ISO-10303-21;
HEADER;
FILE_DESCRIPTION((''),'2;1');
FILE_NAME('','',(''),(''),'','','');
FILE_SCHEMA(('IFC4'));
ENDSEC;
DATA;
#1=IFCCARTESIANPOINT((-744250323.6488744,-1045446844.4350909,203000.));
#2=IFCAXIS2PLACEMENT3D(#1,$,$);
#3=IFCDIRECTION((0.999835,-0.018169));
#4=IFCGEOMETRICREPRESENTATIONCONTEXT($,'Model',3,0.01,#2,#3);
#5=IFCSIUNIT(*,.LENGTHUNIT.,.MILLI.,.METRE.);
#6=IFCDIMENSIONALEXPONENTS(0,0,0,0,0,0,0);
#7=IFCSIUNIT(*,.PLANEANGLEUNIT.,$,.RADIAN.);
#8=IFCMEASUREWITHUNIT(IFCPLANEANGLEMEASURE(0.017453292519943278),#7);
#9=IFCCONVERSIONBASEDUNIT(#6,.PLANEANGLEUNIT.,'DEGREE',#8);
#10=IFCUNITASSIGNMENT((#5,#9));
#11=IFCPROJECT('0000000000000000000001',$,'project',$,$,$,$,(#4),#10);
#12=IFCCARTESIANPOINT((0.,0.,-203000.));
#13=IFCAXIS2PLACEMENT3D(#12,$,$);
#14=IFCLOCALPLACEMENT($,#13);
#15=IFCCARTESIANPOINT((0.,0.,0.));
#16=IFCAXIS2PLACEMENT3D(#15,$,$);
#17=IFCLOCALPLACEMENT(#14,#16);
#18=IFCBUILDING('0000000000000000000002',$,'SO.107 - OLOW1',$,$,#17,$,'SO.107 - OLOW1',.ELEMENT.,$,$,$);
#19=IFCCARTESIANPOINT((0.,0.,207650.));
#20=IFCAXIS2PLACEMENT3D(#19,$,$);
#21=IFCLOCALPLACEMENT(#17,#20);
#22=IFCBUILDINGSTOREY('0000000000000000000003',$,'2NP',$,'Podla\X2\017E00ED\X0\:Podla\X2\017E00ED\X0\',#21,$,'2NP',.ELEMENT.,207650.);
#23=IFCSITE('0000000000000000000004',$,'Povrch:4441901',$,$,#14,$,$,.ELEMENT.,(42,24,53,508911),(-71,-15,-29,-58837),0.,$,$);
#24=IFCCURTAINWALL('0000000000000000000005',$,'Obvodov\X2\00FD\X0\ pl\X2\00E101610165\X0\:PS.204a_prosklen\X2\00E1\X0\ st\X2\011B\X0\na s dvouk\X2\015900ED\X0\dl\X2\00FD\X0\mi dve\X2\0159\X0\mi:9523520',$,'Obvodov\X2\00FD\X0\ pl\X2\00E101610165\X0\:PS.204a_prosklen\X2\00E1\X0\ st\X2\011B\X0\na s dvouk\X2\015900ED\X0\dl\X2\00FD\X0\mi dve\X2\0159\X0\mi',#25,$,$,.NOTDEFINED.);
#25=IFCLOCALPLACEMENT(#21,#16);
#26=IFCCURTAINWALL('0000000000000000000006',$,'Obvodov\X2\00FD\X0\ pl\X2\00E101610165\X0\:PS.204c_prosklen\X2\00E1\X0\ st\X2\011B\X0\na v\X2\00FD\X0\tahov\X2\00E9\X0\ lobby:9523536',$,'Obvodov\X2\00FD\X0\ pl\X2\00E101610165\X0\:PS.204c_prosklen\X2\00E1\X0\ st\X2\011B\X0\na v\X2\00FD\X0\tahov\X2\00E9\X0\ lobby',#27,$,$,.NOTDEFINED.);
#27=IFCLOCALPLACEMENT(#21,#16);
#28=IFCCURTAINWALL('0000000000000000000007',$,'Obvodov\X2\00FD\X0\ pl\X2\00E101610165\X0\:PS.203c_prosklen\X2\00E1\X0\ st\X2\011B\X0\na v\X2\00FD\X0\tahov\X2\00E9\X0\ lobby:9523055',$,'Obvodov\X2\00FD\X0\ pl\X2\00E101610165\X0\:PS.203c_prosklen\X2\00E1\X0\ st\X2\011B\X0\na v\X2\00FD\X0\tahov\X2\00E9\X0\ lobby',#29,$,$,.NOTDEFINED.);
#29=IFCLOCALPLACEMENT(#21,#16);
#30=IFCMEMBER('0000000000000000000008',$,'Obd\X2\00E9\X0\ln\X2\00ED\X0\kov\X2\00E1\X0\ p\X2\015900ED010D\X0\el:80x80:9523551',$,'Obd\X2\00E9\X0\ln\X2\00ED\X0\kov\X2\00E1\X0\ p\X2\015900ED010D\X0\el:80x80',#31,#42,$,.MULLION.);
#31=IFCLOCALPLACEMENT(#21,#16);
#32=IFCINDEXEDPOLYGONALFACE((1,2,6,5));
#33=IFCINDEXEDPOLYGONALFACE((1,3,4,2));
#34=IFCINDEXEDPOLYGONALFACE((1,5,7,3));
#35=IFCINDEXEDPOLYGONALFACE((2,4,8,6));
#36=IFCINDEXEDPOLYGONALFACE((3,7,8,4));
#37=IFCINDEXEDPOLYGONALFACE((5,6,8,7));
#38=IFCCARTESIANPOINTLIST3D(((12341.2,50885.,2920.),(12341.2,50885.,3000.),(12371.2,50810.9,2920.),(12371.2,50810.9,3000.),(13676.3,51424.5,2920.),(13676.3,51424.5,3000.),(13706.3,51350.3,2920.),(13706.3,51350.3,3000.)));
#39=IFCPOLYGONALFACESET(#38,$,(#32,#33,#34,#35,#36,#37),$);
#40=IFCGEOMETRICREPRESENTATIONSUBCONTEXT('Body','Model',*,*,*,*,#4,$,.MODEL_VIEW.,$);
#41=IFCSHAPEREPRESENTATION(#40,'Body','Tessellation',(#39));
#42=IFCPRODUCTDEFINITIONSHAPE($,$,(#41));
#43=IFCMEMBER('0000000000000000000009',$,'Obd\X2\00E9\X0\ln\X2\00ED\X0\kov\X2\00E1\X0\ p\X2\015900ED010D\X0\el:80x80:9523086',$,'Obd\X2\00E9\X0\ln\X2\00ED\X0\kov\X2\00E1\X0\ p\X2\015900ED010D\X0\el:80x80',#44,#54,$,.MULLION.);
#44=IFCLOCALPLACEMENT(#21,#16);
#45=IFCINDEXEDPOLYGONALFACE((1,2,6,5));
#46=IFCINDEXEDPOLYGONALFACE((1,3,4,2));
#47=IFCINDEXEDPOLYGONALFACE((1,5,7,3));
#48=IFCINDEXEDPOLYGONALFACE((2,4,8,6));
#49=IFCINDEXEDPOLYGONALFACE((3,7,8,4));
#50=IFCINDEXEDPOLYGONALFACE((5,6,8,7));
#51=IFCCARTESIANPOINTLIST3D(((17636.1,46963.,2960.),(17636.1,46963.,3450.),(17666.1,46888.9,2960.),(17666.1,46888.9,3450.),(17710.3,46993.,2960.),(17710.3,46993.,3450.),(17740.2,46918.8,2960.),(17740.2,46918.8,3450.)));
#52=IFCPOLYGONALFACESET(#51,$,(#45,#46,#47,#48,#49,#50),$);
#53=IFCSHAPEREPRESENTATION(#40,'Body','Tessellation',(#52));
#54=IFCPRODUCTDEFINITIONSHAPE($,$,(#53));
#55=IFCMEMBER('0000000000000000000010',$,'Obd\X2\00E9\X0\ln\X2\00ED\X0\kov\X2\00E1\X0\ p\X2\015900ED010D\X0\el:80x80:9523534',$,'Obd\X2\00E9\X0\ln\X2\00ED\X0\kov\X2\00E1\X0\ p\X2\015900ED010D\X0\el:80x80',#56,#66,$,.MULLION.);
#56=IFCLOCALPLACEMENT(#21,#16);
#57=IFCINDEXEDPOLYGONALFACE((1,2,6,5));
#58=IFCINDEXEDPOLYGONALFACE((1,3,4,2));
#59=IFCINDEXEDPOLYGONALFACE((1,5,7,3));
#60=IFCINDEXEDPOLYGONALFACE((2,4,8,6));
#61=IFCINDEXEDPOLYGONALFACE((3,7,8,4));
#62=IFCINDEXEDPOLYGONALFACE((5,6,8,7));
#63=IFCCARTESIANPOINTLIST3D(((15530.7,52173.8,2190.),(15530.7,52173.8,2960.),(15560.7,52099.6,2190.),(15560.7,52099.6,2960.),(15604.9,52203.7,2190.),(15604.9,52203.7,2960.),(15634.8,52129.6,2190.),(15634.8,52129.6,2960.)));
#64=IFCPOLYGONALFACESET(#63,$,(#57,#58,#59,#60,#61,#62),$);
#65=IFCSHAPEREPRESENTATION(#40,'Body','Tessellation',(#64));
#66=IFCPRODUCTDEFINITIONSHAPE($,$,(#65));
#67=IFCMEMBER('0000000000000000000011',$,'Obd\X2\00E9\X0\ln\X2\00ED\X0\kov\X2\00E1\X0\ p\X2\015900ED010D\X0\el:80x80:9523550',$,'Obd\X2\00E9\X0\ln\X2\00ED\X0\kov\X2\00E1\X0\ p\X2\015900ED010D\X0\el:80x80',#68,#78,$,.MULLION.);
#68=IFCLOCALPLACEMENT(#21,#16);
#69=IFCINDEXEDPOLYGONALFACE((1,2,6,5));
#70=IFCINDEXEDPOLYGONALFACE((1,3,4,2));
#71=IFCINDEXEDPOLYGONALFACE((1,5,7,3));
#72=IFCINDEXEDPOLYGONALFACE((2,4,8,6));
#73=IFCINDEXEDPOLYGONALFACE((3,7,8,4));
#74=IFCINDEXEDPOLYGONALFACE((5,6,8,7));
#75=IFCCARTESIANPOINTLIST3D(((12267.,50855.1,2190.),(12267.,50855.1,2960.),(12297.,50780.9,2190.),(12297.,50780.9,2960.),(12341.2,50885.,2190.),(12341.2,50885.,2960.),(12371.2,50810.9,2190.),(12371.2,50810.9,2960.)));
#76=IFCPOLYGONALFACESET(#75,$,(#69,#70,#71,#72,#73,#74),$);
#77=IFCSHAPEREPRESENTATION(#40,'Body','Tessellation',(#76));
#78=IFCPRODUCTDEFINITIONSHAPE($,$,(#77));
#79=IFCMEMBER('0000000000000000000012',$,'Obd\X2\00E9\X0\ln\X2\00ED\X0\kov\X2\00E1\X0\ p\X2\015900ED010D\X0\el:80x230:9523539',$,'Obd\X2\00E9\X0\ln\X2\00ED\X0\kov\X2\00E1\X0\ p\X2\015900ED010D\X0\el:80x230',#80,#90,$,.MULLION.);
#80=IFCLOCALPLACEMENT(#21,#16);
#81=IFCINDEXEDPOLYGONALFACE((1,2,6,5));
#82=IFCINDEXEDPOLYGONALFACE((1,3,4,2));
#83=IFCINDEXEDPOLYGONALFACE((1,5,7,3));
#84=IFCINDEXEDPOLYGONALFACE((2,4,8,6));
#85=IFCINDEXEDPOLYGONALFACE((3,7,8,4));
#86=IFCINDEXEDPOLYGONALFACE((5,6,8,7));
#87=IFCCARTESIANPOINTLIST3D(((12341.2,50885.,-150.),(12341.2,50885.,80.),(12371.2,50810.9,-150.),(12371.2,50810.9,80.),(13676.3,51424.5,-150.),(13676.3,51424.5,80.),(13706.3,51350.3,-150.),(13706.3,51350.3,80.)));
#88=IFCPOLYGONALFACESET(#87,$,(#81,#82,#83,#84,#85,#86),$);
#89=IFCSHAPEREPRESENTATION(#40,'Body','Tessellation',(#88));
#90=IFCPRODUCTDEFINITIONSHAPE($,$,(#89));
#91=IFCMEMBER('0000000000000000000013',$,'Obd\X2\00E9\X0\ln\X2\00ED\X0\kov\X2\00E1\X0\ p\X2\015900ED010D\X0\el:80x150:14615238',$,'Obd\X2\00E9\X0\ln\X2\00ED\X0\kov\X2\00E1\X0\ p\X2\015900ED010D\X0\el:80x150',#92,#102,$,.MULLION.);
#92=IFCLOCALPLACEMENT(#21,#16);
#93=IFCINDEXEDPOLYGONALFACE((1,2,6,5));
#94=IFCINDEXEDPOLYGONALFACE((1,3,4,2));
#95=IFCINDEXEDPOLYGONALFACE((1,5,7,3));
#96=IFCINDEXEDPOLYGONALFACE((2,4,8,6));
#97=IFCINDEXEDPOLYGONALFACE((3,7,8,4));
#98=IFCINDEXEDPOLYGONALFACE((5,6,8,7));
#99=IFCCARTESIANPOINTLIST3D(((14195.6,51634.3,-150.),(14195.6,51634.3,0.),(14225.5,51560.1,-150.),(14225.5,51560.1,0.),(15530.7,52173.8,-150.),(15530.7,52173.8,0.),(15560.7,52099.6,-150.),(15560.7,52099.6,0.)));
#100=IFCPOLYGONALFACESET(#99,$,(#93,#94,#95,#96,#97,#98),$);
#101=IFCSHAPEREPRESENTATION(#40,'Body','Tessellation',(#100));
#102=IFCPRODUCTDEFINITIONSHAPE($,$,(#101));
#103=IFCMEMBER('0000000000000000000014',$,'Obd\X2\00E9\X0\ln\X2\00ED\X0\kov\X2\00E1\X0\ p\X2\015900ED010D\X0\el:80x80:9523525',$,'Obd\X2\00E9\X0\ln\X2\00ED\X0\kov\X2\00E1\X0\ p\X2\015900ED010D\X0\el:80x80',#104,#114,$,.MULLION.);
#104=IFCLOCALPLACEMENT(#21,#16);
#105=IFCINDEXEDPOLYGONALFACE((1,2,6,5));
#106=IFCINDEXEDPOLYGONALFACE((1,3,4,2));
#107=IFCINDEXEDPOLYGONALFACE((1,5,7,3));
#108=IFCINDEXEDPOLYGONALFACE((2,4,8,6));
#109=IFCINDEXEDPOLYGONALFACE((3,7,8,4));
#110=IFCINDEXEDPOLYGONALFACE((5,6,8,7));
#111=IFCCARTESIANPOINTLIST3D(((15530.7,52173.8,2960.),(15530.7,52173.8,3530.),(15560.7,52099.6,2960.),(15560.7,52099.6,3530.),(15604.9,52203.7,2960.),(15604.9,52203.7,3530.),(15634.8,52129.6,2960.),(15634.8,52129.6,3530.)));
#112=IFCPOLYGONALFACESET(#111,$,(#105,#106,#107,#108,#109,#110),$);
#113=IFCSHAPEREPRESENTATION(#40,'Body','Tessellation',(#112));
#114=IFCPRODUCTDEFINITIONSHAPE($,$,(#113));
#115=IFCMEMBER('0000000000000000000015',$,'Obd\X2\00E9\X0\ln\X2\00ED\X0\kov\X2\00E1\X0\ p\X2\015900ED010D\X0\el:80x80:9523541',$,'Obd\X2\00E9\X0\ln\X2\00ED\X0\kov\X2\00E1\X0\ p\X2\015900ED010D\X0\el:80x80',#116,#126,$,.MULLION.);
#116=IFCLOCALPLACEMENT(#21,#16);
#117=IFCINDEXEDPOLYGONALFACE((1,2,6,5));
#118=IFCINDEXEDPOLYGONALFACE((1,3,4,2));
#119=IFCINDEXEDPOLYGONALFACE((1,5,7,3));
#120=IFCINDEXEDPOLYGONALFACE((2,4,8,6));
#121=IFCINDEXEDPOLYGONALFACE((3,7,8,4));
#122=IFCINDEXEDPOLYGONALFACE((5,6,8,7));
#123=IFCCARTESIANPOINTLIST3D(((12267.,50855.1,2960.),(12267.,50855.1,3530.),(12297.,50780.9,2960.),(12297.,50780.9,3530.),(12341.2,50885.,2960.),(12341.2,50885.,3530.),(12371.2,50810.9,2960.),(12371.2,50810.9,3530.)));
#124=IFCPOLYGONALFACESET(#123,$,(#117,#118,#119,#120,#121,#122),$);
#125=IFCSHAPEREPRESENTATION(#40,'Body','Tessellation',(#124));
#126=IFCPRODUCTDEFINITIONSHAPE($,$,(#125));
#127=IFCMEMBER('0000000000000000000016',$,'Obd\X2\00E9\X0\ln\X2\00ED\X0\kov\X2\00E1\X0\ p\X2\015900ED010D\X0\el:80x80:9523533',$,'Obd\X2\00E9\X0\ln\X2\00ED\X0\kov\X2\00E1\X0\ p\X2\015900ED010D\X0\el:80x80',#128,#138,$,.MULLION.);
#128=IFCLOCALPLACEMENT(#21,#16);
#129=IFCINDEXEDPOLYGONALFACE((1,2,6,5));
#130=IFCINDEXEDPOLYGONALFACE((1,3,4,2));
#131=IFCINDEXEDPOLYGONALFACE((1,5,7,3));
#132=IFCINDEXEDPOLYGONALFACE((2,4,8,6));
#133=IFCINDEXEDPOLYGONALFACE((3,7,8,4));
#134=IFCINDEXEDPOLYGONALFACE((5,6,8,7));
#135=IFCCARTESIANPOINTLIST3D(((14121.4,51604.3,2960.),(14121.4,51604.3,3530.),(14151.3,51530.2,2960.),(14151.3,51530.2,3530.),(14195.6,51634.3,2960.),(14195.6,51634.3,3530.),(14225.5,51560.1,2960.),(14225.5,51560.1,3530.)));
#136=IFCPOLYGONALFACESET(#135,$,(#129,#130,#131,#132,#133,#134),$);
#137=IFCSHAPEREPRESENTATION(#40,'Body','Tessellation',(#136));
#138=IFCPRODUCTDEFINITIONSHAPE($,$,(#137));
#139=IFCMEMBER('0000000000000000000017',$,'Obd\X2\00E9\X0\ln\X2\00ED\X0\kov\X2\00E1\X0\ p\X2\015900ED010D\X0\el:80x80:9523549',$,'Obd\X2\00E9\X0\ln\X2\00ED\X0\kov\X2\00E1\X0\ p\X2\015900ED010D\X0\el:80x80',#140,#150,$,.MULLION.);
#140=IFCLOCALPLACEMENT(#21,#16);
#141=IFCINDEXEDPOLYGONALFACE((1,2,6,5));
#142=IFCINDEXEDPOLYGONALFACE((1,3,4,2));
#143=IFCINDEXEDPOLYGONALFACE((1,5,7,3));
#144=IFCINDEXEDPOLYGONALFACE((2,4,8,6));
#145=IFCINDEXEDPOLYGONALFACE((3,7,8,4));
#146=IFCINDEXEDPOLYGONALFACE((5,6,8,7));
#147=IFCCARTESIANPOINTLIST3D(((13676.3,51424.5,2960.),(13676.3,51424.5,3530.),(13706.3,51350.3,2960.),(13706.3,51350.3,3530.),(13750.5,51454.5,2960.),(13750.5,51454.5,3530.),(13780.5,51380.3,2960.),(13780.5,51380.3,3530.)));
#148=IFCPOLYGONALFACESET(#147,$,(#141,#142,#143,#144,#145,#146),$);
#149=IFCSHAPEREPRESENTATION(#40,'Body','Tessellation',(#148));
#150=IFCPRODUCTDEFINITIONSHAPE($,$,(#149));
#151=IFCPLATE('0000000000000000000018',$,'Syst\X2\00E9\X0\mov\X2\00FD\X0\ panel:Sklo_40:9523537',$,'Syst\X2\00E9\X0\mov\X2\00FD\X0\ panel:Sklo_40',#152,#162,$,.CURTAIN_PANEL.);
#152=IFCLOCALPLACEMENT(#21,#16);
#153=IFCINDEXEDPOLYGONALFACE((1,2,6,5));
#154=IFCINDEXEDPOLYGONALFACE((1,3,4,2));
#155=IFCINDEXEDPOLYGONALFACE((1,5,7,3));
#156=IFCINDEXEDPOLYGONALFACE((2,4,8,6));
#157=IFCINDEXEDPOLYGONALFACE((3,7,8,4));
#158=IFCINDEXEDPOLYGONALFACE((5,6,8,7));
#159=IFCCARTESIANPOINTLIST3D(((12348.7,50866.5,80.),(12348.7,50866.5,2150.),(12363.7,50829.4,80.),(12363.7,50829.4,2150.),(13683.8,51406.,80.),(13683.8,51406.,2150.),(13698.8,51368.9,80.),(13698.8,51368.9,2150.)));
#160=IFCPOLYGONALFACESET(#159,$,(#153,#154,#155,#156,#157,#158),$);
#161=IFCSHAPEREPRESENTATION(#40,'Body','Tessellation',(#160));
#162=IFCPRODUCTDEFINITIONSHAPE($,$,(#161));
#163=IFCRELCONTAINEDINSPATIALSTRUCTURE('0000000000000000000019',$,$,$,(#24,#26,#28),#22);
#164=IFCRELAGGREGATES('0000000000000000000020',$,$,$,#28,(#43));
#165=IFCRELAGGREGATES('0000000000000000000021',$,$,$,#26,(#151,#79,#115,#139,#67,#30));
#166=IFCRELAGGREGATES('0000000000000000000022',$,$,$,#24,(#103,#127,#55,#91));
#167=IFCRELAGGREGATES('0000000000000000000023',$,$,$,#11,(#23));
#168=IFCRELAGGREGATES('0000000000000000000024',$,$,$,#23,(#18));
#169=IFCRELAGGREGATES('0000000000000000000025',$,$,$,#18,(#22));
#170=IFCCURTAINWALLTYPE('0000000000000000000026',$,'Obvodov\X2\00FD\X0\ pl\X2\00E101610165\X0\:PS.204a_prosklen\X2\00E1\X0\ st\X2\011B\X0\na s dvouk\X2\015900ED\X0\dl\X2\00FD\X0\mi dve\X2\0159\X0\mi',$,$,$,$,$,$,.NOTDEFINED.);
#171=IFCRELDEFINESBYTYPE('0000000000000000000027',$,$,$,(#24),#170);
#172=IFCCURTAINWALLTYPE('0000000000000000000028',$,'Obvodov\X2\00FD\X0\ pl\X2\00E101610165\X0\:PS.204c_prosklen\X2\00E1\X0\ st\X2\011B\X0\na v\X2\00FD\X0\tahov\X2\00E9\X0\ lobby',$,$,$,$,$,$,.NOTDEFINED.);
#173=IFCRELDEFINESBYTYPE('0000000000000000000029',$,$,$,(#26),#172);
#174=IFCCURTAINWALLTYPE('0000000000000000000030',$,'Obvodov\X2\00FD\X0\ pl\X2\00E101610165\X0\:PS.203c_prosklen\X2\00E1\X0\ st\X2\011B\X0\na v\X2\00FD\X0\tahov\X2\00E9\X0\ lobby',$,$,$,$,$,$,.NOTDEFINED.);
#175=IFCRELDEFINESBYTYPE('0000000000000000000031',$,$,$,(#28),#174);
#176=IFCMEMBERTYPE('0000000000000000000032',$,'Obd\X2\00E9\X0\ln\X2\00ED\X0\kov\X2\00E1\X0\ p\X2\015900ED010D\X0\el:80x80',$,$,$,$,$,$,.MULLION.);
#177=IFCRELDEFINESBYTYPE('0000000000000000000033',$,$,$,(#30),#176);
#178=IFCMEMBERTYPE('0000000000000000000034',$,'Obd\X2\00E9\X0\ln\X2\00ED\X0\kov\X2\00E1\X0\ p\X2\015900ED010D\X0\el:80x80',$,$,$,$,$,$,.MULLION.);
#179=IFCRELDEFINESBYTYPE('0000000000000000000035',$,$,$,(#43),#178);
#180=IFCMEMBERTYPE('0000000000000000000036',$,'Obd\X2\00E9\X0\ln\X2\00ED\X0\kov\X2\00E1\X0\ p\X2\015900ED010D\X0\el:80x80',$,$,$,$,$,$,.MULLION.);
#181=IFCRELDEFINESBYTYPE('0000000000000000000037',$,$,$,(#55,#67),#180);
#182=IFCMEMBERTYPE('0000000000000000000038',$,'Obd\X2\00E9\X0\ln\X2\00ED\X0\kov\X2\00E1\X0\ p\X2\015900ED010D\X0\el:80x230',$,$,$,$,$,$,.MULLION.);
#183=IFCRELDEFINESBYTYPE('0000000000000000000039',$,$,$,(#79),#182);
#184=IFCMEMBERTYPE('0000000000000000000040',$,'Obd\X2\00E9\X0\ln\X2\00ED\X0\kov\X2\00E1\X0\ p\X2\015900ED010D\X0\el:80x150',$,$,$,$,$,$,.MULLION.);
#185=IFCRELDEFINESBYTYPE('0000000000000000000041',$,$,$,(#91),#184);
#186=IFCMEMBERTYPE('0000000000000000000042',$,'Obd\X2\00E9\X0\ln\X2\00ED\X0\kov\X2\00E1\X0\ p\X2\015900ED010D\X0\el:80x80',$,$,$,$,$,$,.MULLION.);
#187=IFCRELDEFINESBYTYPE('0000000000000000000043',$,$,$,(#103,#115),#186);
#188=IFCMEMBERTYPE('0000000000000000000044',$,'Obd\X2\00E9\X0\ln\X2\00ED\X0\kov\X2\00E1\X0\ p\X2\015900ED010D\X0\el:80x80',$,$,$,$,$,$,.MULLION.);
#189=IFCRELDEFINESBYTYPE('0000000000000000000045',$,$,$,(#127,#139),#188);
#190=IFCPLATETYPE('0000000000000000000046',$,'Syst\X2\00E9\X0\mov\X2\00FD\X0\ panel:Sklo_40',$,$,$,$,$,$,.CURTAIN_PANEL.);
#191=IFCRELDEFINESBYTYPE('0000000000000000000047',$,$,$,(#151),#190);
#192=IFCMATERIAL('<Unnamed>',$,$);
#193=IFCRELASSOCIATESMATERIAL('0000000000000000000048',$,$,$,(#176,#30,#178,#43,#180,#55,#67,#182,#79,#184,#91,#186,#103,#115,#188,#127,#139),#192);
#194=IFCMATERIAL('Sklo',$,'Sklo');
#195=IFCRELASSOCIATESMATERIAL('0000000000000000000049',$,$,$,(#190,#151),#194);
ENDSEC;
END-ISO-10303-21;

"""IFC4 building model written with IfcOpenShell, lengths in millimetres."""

from ifc_helpers import new_model, entity, si_unit, converted_unit, direction, frame, origin, place, context, subcontext, project, spatial, indexed_curve, outline, extrude, source, transform, mapped, material, type_object, type_shapes, element, aggregate, save


model = new_model("IFC4")

# Units and contexts
model_context = context("Model", 3, precision=0.01, world=frame((-744250323.6488744, -1045446844.4350909, 203000.0)), true_north=direction((0.999835, -0.018169)))
body_context = subcontext(model_context, "Body", "Model", "MODEL_VIEW")
ifc_project = project(units=[si_unit("LENGTHUNIT", "METRE", prefix="MILLI"), converted_unit("PLANEANGLEUNIT", "DEGREE", entity("IfcPlaneAngleMeasure", 0.017453292519943278), si_unit("PLANEANGLEUNIT", "RADIAN"), dimensions=[0, 0, 0, 0, 0, 0, 0])], contexts=[model_context])

# Site, building, storey
site_placement = place(None, frame((0.0, 0.0, -203000.0)))
site = spatial("IfcSite", under=ifc_project, at=site_placement, Name="Povrch:4441901", CompositionType="ELEMENT", RefLatitude=(42, 24, 53, 508911), RefLongitude=(-71, -15, -29, -58837), RefElevation=0.0)
building_placement = place(site_placement, origin())
building = spatial("IfcBuilding", under=site, at=building_placement, Name="SO.107 - OLOW1", LongName="SO.107 - OLOW1", CompositionType="ELEMENT")
storey_placement = place(building_placement, frame((0.0, 0.0, 207650.0)))
storey = spatial("IfcBuildingStorey", under=building, at=storey_placement, Name="2NP", ObjectType="Podlaží:Podlaží", LongName="2NP", CompositionType="ELEMENT", Elevation=207650.0)

# Curtain walls
curtain_wall_type_1 = type_object("IfcCurtainWallType", Name="Obvodový plášť:PS.204a_prosklená stěna s dvoukřídlými dveřmi", PredefinedType="NOTDEFINED")
curtain_wall_1_placement = place(storey_placement, frame((0.0, 0.0, -207650.0)))
curtain_wall_1 = element("IfcCurtainWall", 1, at=curtain_wall_1_placement, inside=storey, type_object=curtain_wall_type_1, Name="Obvodový plášť:PS.204a_prosklená stěna s dvoukřídlými dveřmi:9523520", ObjectType="Obvodový plášť:PS.204a_prosklená stěna s dvoukřídlými dveřmi", PredefinedType="NOTDEFINED")
ifc_material_1 = material(Name="<Unnamed>")
curtain_wall_type_2 = type_object("IfcCurtainWallType", Name="Obvodový plášť:PS.204c_prosklená stěna výtahové lobby", PredefinedType="NOTDEFINED")
curtain_wall_2_placement = place(storey_placement, frame((0.0, 0.0, -207650.0)))
curtain_wall_2 = element("IfcCurtainWall", 2, at=curtain_wall_2_placement, inside=storey, type_object=curtain_wall_type_2, Name="Obvodový plášť:PS.204c_prosklená stěna výtahové lobby:9523536", ObjectType="Obvodový plášť:PS.204c_prosklená stěna výtahové lobby", PredefinedType="NOTDEFINED")
curtain_wall_type_3 = type_object("IfcCurtainWallType", Name="Obvodový plášť:PS.203c_prosklená stěna výtahové lobby", PredefinedType="NOTDEFINED")
curtain_wall_3_placement = place(storey_placement, frame((0.0, 0.0, -207650.0)))
curtain_wall_3 = element("IfcCurtainWall", 3, at=curtain_wall_3_placement, inside=storey, type_object=curtain_wall_type_3, Name="Obvodový plášť:PS.203c_prosklená stěna výtahové lobby:9523055", ObjectType="Obvodový plášť:PS.203c_prosklená stěna výtahové lobby", PredefinedType="NOTDEFINED")

# Members
member_type_1 = type_object("IfcMemberType", Name="Obdélníková příčel:80x80", PredefinedType="MULLION", material=ifc_material_1)
shared_shape_1 = source(origin(), body_context, "Body", "SweptSolid", [
    extrude(outline(indexed_curve([(-40.0, -40.0), (40.0, -40.0), (40.0, 40.0), (-40.0, 40.0), (-40.0, -40.0)], self_intersect=False)), frame((0.0, 0.0, -1440.0), z_axis=(0.0, 0.0, 1.0), x_axis=(-1.0, 0.0, 0.0)), (0.0, 0.0, 1.0), 1440.0),
])
type_shapes(member_type_1, [shared_shape_1])
member_1_placement = place(curtain_wall_2_placement, frame((13691.3, 51387.4, 210610.0), z_axis=(0.927176, 0.374626, 0.0), x_axis=(0.0, 0.0, 1.0)))
member_1 = element("IfcMember", 4, at=member_1_placement, type_object=member_type_1, material=ifc_material_1, Name="Obdélníková příčel:80x80:9523551", ObjectType="Obdélníková příčel:80x80", PredefinedType="MULLION", context=body_context, shape_type="MappedRepresentation", body=[
    mapped(shared_shape_1, transform((0.0, 0.0, 0.0), scale=1.0)),
])
member_type_2 = type_object("IfcMemberType", Name="Obdélníková příčel:80x80", PredefinedType="MULLION", material=ifc_material_1)
shared_shape_2 = source(origin(), body_context, "Body", "SweptSolid", [
    extrude(outline(indexed_curve([(-40.0, -40.0), (40.0, -40.0), (40.0, 40.0), (-40.0, 40.0), (-40.0, -40.0)], self_intersect=False)), frame((-40.0, 0.0, -490.0), z_axis=(0.0, 0.0, 1.0), x_axis=(-1.0, 0.0, 0.0)), (0.0, 0.0, 1.0), 490.0),
])
type_shapes(member_type_2, [shared_shape_2])
member_2_placement = place(curtain_wall_3_placement, frame((17725.2, 46955.9, 210610.0), z_axis=(0.0, 0.0, -1.0), x_axis=(0.927176, 0.374626, 0.0)))
member_2 = element("IfcMember", 5, at=member_2_placement, type_object=member_type_2, material=ifc_material_1, Name="Obdélníková příčel:80x80:9523086", ObjectType="Obdélníková příčel:80x80", PredefinedType="MULLION", context=body_context, shape_type="MappedRepresentation", body=[
    mapped(shared_shape_2, transform((0.0, 0.0, 0.0), scale=1.0)),
])
aggregate(curtain_wall_3, [member_2])
member_type_3 = type_object("IfcMemberType", Name="Obdélníková příčel:80x80", PredefinedType="MULLION", material=ifc_material_1)
shared_shape_3 = source(origin(), body_context, "Body", "SweptSolid", [
    extrude(outline(indexed_curve([(-40.0, -40.0), (40.0, -40.0), (40.0, 40.0), (-40.0, 40.0), (-40.0, -40.0)], self_intersect=False)), frame((-40.0, 0.0, -770.0), z_axis=(0.0, 0.0, 1.0), x_axis=(-1.0, 0.0, 0.0)), (0.0, 0.0, 1.0), 770.0),
])
type_shapes(member_type_3, [shared_shape_3])
member_3_placement = place(curtain_wall_1_placement, frame((15619.8, 52166.6, 210610.0), z_axis=(0.0, 0.0, 1.0), x_axis=(0.927176, 0.374626, 0.0)))
member_3 = element("IfcMember", 6, at=member_3_placement, type_object=member_type_3, material=ifc_material_1, Name="Obdélníková příčel:80x80:9523534", ObjectType="Obdélníková příčel:80x80", PredefinedType="MULLION", context=body_context, shape_type="MappedRepresentation", body=[
    mapped(shared_shape_3, transform((0.0, 0.0, 0.0), scale=1.0)),
])
member_4_placement = place(curtain_wall_2_placement, frame((12282.0, 50818.0, 210610.0), z_axis=(0.0, 0.0, 1.0), x_axis=(-0.927176, -0.374626, 0.0)))
member_4 = element("IfcMember", 7, at=member_4_placement, type_object=member_type_3, material=ifc_material_1, Name="Obdélníková příčel:80x80:9523550", ObjectType="Obdélníková příčel:80x80", PredefinedType="MULLION", context=body_context, shape_type="MappedRepresentation", body=[
    mapped(shared_shape_3, transform((0.0, 0.0, 0.0), scale=1.0)),
])
member_type_4 = type_object("IfcMemberType", Name="Obdélníková příčel:80x230", PredefinedType="MULLION", material=ifc_material_1)
shared_shape_4 = source(origin(), body_context, "Body", "SweptSolid", [
    extrude(outline(indexed_curve([(-115.0, -40.0), (115.0, -40.0), (115.0, 40.0), (-115.0, 40.0), (-115.0, -40.0)], self_intersect=False)), frame((-115.0, 0.0, -1440.0), z_axis=(0.0, 0.0, 1.0), x_axis=(-1.0, 0.0, 0.0)), (0.0, 0.0, 1.0), 1440.0),
])
type_shapes(member_type_4, [shared_shape_4])
member_5_placement = place(curtain_wall_2_placement, frame((12356.2, 50848.0, 207500.0), z_axis=(-0.927176, -0.374626, 0.0), x_axis=(0.0, 0.0, -1.0)))
member_5 = element("IfcMember", 8, at=member_5_placement, type_object=member_type_4, material=ifc_material_1, Name="Obdélníková příčel:80x230:9523539", ObjectType="Obdélníková příčel:80x230", PredefinedType="MULLION", context=body_context, shape_type="MappedRepresentation", body=[
    mapped(shared_shape_4, transform((0.0, 0.0, 0.0), scale=1.0)),
])
member_type_5 = type_object("IfcMemberType", Name="Obdélníková příčel:80x150", PredefinedType="MULLION", material=ifc_material_1)
shared_shape_5 = source(origin(), body_context, "Body", "SweptSolid", [
    extrude(outline(indexed_curve([(-75.0, -40.0), (75.0, -40.0), (75.0, 40.0), (-75.0, 40.0), (-75.0, -40.0)], self_intersect=False)), frame((-75.0, 0.0, -1440.0), z_axis=(0.0, 0.0, 1.0), x_axis=(-1.0, 0.0, 0.0)), (0.0, 0.0, 1.0), 1440.0),
])
type_shapes(member_type_5, [shared_shape_5])
member_6_placement = place(curtain_wall_1_placement, frame((15545.7, 52136.7, 207500.0), z_axis=(0.927176, 0.374626, 0.0), x_axis=(0.0, 0.0, -1.0)))
member_6 = element("IfcMember", 9, at=member_6_placement, type_object=member_type_5, material=ifc_material_1, Name="Obdélníková příčel:80x150:14615238", ObjectType="Obdélníková příčel:80x150", PredefinedType="MULLION", context=body_context, shape_type="MappedRepresentation", body=[
    mapped(shared_shape_5, transform((0.0, 0.0, 0.0), scale=1.0)),
])
member_type_6 = type_object("IfcMemberType", Name="Obdélníková příčel:80x80", PredefinedType="MULLION", material=ifc_material_1)
shared_shape_6 = source(origin(), body_context, "Body", "SweptSolid", [
    extrude(outline(indexed_curve([(-40.0, -40.0), (40.0, -40.0), (40.0, 40.0), (-40.0, 40.0), (-40.0, -40.0)], self_intersect=False)), frame((-40.0, 0.0, -570.0), z_axis=(0.0, 0.0, 1.0), x_axis=(-1.0, 0.0, 0.0)), (0.0, 0.0, 1.0), 570.0),
])
type_shapes(member_type_6, [shared_shape_6])
member_7_placement = place(curtain_wall_1_placement, frame((15619.8, 52166.6, 211180.0), z_axis=(0.0, 0.0, 1.0), x_axis=(0.927176, 0.374626, 0.0)))
member_7 = element("IfcMember", 10, at=member_7_placement, type_object=member_type_6, material=ifc_material_1, Name="Obdélníková příčel:80x80:9523525", ObjectType="Obdélníková příčel:80x80", PredefinedType="MULLION", context=body_context, shape_type="MappedRepresentation", body=[
    mapped(shared_shape_6, transform((0.0, 0.0, 0.0), scale=1.0)),
])
member_8_placement = place(curtain_wall_2_placement, frame((12282.0, 50818.0, 211180.0), z_axis=(0.0, 0.0, 1.0), x_axis=(-0.927176, -0.374626, 0.0)))
member_8 = element("IfcMember", 11, at=member_8_placement, type_object=member_type_6, material=ifc_material_1, Name="Obdélníková příčel:80x80:9523541", ObjectType="Obdélníková příčel:80x80", PredefinedType="MULLION", context=body_context, shape_type="MappedRepresentation", body=[
    mapped(shared_shape_6, transform((0.0, 0.0, 0.0), scale=1.0)),
])
member_type_7 = type_object("IfcMemberType", Name="Obdélníková příčel:80x80", PredefinedType="MULLION", material=ifc_material_1)
shared_shape_7 = source(origin(), body_context, "Body", "SweptSolid", [
    extrude(outline(indexed_curve([(-40.0, -40.0), (40.0, -40.0), (40.0, 40.0), (-40.0, 40.0), (-40.0, -40.0)], self_intersect=False)), frame((-40.0, 0.0, -570.0), z_axis=(0.0, 0.0, 1.0), x_axis=(-1.0, 0.0, 0.0)), (0.0, 0.0, 1.0), 570.0),
])
type_shapes(member_type_7, [shared_shape_7])
member_9_placement = place(curtain_wall_1_placement, frame((14136.4, 51567.2, 210610.0), z_axis=(0.0, 0.0, -1.0), x_axis=(-0.927176, -0.374626, 0.0)))
member_9 = element("IfcMember", 12, at=member_9_placement, type_object=member_type_7, material=ifc_material_1, Name="Obdélníková příčel:80x80:9523533", ObjectType="Obdélníková příčel:80x80", PredefinedType="MULLION", context=body_context, shape_type="MappedRepresentation", body=[
    mapped(shared_shape_7, transform((0.0, 0.0, 0.0), scale=1.0)),
])
member_10_placement = place(curtain_wall_2_placement, frame((13765.5, 51417.4, 210610.0), z_axis=(0.0, 0.0, -1.0), x_axis=(0.927176, 0.374626, 0.0)))
member_10 = element("IfcMember", 13, at=member_10_placement, type_object=member_type_7, material=ifc_material_1, Name="Obdélníková příčel:80x80:9523549", ObjectType="Obdélníková příčel:80x80", PredefinedType="MULLION", context=body_context, shape_type="MappedRepresentation", body=[
    mapped(shared_shape_7, transform((0.0, 0.0, 0.0), scale=1.0)),
])

# Plate
ifc_material_2 = material(Name="Sklo", Category="Sklo")
plate_type_1 = type_object("IfcPlateType", Name="Systémový panel:Sklo_40", PredefinedType="CURTAIN_PANEL", material=ifc_material_2)
shared_shape_8 = source(origin(), body_context, "Body", "SweptSolid", [
    extrude(outline(indexed_curve([(-20.0, -720.0), (20.0, -720.0), (20.0, 720.0), (-20.0, 720.0), (-20.0, -720.0)], self_intersect=False)), frame((0.0, 0.0, 0.0), z_axis=(0.0, 0.0, 1.0), x_axis=(0.0, 1.0, 0.0)), (0.0, 0.0, 1.0), 2070.0),
])
type_shapes(plate_type_1, [shared_shape_8])
plate_1_placement = place(curtain_wall_2_placement, frame((13023.8, 51117.7, 207730.0), z_axis=(0.0, 0.0, 1.0), x_axis=(0.927176, 0.374626, 0.0)))
plate_1 = element("IfcPlate", 14, at=plate_1_placement, type_object=plate_type_1, material=ifc_material_2, Name="Systémový panel:Sklo_40:9523537", ObjectType="Systémový panel:Sklo_40", PredefinedType="CURTAIN_PANEL", context=body_context, shape_type="MappedRepresentation", body=[
    mapped(shared_shape_8, transform((0.0, 0.0, 0.0), scale=1.0)),
])
aggregate(curtain_wall_2, [plate_1, member_5, member_8, member_10, member_4, member_1])

aggregate(curtain_wall_1, [member_7, member_9, member_3, member_6])

save(model, "model.ifc")
